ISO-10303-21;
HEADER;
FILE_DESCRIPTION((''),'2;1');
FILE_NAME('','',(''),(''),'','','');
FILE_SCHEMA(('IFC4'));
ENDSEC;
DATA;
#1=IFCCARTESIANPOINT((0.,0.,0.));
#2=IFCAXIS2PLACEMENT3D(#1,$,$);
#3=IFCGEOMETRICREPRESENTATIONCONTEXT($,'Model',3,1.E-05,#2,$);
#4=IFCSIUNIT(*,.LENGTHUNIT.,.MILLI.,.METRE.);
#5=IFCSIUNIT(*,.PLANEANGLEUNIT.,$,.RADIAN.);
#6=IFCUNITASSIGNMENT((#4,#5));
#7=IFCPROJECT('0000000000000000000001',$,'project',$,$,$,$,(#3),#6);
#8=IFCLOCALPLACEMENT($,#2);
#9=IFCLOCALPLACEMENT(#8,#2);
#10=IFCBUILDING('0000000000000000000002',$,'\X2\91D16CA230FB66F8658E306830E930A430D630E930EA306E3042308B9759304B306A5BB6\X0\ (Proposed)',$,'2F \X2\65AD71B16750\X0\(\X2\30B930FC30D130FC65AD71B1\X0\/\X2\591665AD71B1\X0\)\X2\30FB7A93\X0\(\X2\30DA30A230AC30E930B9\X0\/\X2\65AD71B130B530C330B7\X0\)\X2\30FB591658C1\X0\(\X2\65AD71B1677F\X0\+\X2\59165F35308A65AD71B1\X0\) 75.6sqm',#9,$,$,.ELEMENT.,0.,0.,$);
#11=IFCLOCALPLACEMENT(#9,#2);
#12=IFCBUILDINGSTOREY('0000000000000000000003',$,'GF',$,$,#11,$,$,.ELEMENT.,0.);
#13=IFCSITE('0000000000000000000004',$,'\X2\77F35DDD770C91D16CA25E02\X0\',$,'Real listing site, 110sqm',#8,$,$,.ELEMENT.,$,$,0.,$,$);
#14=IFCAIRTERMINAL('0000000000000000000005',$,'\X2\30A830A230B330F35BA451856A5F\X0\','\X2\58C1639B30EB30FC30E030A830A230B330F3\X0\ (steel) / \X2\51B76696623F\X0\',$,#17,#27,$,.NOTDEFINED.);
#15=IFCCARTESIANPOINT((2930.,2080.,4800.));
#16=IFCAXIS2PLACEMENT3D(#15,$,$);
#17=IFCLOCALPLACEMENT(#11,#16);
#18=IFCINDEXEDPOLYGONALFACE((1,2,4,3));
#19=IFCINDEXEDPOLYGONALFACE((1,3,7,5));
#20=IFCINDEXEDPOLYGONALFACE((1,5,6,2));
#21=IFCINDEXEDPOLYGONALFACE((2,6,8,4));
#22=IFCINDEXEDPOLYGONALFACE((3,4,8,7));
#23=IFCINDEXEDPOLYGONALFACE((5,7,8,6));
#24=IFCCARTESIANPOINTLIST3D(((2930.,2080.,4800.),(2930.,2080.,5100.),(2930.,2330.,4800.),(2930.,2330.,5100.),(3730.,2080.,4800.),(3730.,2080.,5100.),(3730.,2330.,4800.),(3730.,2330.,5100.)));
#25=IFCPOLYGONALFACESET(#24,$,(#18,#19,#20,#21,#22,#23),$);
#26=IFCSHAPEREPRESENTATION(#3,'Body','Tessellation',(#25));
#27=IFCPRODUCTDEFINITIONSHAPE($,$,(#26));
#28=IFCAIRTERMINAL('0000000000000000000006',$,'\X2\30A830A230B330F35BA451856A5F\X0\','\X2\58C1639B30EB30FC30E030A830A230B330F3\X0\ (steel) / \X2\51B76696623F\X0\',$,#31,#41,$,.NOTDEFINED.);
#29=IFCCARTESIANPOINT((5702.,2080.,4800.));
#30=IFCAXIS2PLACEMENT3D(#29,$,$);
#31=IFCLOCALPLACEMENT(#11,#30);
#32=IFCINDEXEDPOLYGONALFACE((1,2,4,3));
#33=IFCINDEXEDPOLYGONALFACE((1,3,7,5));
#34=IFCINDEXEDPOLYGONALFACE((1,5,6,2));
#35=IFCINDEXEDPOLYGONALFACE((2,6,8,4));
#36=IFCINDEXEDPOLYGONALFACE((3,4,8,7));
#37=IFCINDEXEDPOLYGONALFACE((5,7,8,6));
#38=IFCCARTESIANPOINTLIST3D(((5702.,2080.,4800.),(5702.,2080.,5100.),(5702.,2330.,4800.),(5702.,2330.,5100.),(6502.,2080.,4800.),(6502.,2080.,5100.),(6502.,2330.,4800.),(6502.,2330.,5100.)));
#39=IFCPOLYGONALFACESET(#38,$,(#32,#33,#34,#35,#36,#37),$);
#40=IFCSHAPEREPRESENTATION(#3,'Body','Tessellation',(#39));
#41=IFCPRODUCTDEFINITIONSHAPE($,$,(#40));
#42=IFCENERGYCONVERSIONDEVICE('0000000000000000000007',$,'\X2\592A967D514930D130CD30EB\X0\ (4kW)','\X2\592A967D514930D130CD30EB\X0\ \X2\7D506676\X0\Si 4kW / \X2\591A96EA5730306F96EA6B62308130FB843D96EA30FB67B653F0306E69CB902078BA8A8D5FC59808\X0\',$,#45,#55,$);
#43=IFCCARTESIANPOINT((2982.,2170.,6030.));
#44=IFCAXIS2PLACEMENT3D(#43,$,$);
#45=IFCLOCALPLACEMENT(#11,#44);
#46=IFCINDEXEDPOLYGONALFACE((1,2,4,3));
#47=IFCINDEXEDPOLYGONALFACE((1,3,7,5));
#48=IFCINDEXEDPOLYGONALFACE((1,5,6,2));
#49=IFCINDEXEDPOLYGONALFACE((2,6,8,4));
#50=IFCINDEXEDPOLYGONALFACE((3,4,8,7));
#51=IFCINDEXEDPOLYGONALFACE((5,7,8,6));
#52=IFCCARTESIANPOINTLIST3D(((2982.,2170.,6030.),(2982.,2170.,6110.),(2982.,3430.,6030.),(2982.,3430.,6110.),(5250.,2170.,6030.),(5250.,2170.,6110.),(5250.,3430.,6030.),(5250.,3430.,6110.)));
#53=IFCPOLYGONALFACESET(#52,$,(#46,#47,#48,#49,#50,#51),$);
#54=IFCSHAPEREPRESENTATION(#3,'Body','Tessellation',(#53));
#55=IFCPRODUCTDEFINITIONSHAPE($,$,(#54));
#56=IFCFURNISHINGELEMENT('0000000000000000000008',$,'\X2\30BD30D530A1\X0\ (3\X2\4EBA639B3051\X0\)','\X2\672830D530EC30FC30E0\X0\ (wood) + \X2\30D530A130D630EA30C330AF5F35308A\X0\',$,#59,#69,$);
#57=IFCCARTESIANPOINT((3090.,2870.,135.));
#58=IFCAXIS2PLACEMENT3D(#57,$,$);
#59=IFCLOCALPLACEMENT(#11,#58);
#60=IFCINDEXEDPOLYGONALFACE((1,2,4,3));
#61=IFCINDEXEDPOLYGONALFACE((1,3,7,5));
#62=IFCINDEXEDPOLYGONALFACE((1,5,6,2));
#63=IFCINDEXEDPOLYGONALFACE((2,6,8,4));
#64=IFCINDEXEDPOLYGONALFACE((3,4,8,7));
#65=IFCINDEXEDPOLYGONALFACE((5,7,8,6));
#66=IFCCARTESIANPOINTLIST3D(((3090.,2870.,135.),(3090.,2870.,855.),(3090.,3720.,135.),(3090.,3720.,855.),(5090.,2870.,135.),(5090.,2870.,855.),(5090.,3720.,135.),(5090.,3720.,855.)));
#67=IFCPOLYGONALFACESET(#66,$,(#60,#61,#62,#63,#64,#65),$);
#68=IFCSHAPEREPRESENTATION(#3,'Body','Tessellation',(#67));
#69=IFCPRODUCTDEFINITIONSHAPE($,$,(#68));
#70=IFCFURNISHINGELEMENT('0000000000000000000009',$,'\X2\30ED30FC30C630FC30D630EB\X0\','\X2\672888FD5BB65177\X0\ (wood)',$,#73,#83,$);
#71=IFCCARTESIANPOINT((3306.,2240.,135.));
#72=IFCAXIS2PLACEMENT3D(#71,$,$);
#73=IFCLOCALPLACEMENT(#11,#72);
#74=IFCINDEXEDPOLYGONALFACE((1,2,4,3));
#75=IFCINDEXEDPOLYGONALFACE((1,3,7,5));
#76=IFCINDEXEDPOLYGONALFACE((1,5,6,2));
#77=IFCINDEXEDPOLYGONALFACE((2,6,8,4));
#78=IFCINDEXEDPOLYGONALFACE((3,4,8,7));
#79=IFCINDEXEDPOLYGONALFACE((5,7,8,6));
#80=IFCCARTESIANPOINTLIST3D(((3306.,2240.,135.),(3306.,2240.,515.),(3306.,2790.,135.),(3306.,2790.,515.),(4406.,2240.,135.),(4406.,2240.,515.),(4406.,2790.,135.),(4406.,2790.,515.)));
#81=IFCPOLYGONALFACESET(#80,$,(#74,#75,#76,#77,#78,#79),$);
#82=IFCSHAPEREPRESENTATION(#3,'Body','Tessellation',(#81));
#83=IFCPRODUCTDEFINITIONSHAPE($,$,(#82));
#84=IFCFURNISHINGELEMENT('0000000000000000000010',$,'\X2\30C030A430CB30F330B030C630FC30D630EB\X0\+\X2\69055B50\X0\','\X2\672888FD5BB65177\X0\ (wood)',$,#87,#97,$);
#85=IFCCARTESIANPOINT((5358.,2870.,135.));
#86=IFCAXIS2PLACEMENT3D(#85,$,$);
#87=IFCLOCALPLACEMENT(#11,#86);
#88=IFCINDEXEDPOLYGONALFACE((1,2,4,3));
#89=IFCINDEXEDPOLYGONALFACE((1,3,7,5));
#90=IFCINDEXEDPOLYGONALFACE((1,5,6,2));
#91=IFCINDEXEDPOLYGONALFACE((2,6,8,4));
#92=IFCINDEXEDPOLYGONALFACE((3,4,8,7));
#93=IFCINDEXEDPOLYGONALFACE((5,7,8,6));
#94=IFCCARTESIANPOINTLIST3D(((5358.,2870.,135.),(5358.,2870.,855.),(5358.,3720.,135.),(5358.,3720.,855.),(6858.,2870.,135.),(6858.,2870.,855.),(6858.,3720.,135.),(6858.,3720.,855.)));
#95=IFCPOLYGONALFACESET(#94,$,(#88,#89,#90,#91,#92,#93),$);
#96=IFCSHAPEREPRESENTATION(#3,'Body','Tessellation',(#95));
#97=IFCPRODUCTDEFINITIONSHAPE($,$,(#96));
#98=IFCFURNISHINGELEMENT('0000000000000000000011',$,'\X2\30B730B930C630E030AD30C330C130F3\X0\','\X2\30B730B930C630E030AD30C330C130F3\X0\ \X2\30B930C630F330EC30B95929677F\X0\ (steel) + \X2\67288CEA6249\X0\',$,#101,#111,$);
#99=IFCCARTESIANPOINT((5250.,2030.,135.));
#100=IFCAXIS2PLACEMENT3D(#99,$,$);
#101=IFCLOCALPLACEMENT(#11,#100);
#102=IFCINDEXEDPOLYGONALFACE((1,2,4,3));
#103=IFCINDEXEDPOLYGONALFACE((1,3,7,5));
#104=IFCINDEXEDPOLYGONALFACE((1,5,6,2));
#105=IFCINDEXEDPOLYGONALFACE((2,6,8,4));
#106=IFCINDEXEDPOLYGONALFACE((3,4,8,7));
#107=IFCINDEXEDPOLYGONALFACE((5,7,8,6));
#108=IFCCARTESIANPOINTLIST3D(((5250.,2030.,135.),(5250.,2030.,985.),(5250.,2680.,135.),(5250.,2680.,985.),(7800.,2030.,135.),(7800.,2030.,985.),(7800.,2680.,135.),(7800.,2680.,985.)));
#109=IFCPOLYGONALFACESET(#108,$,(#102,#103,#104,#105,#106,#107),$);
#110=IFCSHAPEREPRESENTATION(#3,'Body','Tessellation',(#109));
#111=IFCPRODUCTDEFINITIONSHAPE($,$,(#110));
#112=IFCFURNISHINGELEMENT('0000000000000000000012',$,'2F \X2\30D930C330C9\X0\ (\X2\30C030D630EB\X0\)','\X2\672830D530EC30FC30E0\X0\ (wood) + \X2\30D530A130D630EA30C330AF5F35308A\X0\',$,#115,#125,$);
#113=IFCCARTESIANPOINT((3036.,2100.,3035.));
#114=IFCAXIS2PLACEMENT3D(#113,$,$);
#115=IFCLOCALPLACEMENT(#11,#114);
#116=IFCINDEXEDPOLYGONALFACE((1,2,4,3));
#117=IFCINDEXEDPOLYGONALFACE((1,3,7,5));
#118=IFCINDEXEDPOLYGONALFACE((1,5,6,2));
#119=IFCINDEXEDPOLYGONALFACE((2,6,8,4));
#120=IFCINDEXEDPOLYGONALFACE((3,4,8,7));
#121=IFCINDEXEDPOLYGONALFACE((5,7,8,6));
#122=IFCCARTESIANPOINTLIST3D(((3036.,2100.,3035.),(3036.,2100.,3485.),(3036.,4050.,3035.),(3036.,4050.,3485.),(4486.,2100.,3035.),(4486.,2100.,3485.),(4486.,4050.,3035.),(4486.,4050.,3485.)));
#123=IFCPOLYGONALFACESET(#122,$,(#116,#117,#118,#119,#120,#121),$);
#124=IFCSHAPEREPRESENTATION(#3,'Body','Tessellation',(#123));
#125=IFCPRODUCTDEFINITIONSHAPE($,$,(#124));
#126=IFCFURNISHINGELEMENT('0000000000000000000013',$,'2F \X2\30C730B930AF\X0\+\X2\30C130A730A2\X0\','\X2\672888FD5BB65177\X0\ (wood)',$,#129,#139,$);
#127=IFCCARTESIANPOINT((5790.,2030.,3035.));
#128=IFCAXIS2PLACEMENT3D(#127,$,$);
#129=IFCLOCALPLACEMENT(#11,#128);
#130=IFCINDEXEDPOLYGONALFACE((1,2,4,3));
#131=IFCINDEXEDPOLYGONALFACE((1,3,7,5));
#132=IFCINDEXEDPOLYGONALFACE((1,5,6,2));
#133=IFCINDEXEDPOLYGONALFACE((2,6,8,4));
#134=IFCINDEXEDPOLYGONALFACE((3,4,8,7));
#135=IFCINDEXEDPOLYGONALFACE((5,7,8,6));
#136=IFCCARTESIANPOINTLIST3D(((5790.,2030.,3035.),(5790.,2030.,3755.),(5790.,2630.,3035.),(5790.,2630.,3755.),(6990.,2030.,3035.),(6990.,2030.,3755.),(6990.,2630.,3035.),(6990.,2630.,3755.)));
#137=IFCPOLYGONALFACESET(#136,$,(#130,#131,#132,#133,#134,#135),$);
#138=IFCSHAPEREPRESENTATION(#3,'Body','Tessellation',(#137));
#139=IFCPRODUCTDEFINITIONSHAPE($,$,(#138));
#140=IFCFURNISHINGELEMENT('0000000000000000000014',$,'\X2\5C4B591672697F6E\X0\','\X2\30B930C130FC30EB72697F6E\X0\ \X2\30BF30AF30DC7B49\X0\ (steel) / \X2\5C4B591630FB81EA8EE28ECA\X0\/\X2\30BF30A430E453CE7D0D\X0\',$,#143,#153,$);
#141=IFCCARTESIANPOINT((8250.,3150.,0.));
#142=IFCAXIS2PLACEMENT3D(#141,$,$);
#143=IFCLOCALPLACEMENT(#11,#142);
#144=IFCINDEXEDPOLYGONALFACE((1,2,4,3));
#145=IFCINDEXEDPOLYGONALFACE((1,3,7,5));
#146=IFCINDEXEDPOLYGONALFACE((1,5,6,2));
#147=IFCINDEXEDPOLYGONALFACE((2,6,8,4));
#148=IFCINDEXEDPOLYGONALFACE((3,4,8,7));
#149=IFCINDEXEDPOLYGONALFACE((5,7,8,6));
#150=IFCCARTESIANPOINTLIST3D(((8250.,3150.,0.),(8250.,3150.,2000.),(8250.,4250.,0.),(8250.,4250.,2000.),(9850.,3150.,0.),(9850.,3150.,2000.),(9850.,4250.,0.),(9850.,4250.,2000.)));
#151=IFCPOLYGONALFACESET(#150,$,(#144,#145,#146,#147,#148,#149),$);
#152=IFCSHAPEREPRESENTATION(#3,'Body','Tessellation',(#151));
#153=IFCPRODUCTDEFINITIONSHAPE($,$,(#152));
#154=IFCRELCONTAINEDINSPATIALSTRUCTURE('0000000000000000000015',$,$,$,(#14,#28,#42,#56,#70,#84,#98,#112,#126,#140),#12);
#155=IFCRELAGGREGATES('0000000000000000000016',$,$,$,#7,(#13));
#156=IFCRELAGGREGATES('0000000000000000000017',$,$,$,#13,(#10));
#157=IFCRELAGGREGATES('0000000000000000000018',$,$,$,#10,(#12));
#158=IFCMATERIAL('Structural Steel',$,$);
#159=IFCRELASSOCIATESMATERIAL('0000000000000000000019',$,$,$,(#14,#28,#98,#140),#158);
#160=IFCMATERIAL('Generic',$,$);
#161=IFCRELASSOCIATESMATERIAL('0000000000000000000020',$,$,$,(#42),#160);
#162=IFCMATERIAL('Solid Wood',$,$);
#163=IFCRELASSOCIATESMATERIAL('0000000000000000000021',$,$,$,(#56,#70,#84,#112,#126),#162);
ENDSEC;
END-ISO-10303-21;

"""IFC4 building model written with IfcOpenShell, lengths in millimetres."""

from ifc_helpers import new_model, si_unit, frame, frame_2d, origin, place, context, project, spatial, rectangle, extrude, material, element, save


model = new_model("IFC4")

# Units and contexts
model_context = context("Model", 3, precision=1e-05, world=origin())
ifc_project = project(units=[si_unit("LENGTHUNIT", "METRE", prefix="MILLI"), si_unit("PLANEANGLEUNIT", "RADIAN")], contexts=[model_context])

# Site, building, storey
site_placement = place(None, origin())
site = spatial("IfcSite", under=ifc_project, at=site_placement, Name="石川県金沢市", ObjectType="Real listing site, 110sqm", CompositionType="ELEMENT", RefElevation=0.0)
building_placement = place(site_placement, origin())
building = spatial("IfcBuilding", under=site, at=building_placement, Name="金沢・書斎とライブラリのある静かな家 (Proposed)", ObjectType="2F 断熱材(スーパー断熱/外断熱)・窓(ペアガラス/断熱サッシ)・外壁(断熱板+外張り断熱) 75.6sqm", CompositionType="ELEMENT", ElevationOfRefHeight=0.0, ElevationOfTerrain=0.0)
storey_placement = place(building_placement, origin())
storey = spatial("IfcBuildingStorey", under=building, at=storey_placement, Name="GF", CompositionType="ELEMENT", Elevation=0.0)

# Shared definitions
ifc_material_1 = material(Name="Solid Wood")

# Shared definitions
ifc_material_2 = material(Name="Generic")

# Shared definitions
ifc_material_3 = material(Name="Structural Steel")

# Air terminals
air_terminal_1_placement = place(storey_placement, frame((2930.0, 2080.0, 4800.0)))
element("IfcAirTerminal", 1, at=air_terminal_1_placement, inside=storey, material=ifc_material_3, Name="エアコン室内機", Description="壁掛ルームエアコン (steel) / 冷暖房", PredefinedType="NOTDEFINED", context=model_context, shape_type="SweptSolid", body=[
    extrude(rectangle(XDim=800.0, YDim=250.0, at=frame_2d((400.0, 125.0))), frame((2930.0, 2080.0, 4800.0)), (0.0, 0.0, 1.0), 300.0),
])
air_terminal_2_placement = place(storey_placement, frame((5702.0, 2080.0, 4800.0)))
element("IfcAirTerminal", 2, at=air_terminal_2_placement, inside=storey, material=ifc_material_3, Name="エアコン室内機", Description="壁掛ルームエアコン (steel) / 冷暖房", PredefinedType="NOTDEFINED", context=model_context, shape_type="SweptSolid", body=[
    extrude(rectangle(XDim=800.0, YDim=250.0, at=frame_2d((400.0, 125.0))), frame((5702.0, 2080.0, 4800.0)), (0.0, 0.0, 1.0), 300.0),
])

# Energy conversion device
energy_conversion_device_placement = place(storey_placement, frame((2982.0, 2170.0, 6030.0)))
element("IfcEnergyConversionDevice", 3, at=energy_conversion_device_placement, inside=storey, material=ifc_material_2, Name="太陽光パネル (4kW)", Description="太陽光パネル 結晶Si 4kW / 多雪地は雪止め・落雪・架台の構造確認必須", context=model_context, shape_type="SweptSolid", body=[
    extrude(rectangle(XDim=2268.0, YDim=1260.0, at=frame_2d((1134.0, 630.0))), frame((2982.0, 2170.0, 6030.0)), (0.0, 0.0, 1.0), 80.0),
])

# Furnishing elements
furnishing_1_placement = place(storey_placement, frame((3090.0, 2870.0, 135.0)))
element("IfcFurnishingElement", 4, at=furnishing_1_placement, inside=storey, material=ifc_material_1, Name="ソファ (3人掛け)", Description="木フレーム (wood) + ファブリック張り", context=model_context, shape_type="SweptSolid", body=[
    extrude(rectangle(XDim=2000.0, YDim=850.0, at=frame_2d((1000.0, 425.0))), frame((3090.0, 2870.0, 135.0)), (0.0, 0.0, 1.0), 720.0),
])
furnishing_2_placement = place(storey_placement, frame((3306.0, 2240.0, 135.0)))
element("IfcFurnishingElement", 5, at=furnishing_2_placement, inside=storey, material=ifc_material_1, Name="ローテーブル", Description="木製家具 (wood)", context=model_context, shape_type="SweptSolid", body=[
    extrude(rectangle(XDim=1100.0, YDim=550.0, at=frame_2d((550.0, 275.0))), frame((3306.0, 2240.0, 135.0)), (0.0, 0.0, 1.0), 380.0),
])
furnishing_3_placement = place(storey_placement, frame((5358.0, 2870.0, 135.0)))
element("IfcFurnishingElement", 6, at=furnishing_3_placement, inside=storey, material=ifc_material_1, Name="ダイニングテーブル+椅子", Description="木製家具 (wood)", context=model_context, shape_type="SweptSolid", body=[
    extrude(rectangle(XDim=1500.0, YDim=850.0, at=frame_2d((750.0, 425.0))), frame((5358.0, 2870.0, 135.0)), (0.0, 0.0, 1.0), 720.0),
])
furnishing_4_placement = place(storey_placement, frame((5250.0, 2030.0, 135.0)))
element("IfcFurnishingElement", 7, at=furnishing_4_placement, inside=storey, material=ifc_material_3, Name="システムキッチン", Description="システムキッチン ステンレス天板 (steel) + 木質扉", context=model_context, shape_type="SweptSolid", body=[
    extrude(rectangle(XDim=2550.0, YDim=650.0, at=frame_2d((1275.0, 325.0))), frame((5250.0, 2030.0, 135.0)), (0.0, 0.0, 1.0), 850.0),
])
furnishing_5_placement = place(storey_placement, frame((3036.0, 2100.0, 3035.0)))
element("IfcFurnishingElement", 8, at=furnishing_5_placement, inside=storey, material=ifc_material_1, Name="2F ベッド (ダブル)", Description="木フレーム (wood) + ファブリック張り", context=model_context, shape_type="SweptSolid", body=[
    extrude(rectangle(XDim=1450.0, YDim=1950.0, at=frame_2d((725.0, 975.0))), frame((3036.0, 2100.0, 3035.0)), (0.0, 0.0, 1.0), 450.0),
])
furnishing_6_placement = place(storey_placement, frame((5790.0, 2030.0, 3035.0)))
element("IfcFurnishingElement", 9, at=furnishing_6_placement, inside=storey, material=ifc_material_1, Name="2F デスク+チェア", Description="木製家具 (wood)", context=model_context, shape_type="SweptSolid", body=[
    extrude(rectangle(XDim=1200.0, YDim=600.0, at=frame_2d((600.0, 300.0))), frame((5790.0, 2030.0, 3035.0)), (0.0, 0.0, 1.0), 720.0),
])
furnishing_7_placement = place(storey_placement, frame((8250.0, 3150.0, 0.0)))
element("IfcFurnishingElement", 10, at=furnishing_7_placement, inside=storey, material=ifc_material_3, Name="屋外物置", Description="スチール物置 タクボ等 (steel) / 屋外・自転車/タイヤ収納", context=model_context, shape_type="SweptSolid", body=[
    extrude(rectangle(XDim=1600.0, YDim=1100.0, at=frame_2d((800.0, 550.0))), frame((8250.0, 3150.0, 0.0)), (0.0, 0.0, 1.0), 2000.0),
])

save(model, "model.ifc")
